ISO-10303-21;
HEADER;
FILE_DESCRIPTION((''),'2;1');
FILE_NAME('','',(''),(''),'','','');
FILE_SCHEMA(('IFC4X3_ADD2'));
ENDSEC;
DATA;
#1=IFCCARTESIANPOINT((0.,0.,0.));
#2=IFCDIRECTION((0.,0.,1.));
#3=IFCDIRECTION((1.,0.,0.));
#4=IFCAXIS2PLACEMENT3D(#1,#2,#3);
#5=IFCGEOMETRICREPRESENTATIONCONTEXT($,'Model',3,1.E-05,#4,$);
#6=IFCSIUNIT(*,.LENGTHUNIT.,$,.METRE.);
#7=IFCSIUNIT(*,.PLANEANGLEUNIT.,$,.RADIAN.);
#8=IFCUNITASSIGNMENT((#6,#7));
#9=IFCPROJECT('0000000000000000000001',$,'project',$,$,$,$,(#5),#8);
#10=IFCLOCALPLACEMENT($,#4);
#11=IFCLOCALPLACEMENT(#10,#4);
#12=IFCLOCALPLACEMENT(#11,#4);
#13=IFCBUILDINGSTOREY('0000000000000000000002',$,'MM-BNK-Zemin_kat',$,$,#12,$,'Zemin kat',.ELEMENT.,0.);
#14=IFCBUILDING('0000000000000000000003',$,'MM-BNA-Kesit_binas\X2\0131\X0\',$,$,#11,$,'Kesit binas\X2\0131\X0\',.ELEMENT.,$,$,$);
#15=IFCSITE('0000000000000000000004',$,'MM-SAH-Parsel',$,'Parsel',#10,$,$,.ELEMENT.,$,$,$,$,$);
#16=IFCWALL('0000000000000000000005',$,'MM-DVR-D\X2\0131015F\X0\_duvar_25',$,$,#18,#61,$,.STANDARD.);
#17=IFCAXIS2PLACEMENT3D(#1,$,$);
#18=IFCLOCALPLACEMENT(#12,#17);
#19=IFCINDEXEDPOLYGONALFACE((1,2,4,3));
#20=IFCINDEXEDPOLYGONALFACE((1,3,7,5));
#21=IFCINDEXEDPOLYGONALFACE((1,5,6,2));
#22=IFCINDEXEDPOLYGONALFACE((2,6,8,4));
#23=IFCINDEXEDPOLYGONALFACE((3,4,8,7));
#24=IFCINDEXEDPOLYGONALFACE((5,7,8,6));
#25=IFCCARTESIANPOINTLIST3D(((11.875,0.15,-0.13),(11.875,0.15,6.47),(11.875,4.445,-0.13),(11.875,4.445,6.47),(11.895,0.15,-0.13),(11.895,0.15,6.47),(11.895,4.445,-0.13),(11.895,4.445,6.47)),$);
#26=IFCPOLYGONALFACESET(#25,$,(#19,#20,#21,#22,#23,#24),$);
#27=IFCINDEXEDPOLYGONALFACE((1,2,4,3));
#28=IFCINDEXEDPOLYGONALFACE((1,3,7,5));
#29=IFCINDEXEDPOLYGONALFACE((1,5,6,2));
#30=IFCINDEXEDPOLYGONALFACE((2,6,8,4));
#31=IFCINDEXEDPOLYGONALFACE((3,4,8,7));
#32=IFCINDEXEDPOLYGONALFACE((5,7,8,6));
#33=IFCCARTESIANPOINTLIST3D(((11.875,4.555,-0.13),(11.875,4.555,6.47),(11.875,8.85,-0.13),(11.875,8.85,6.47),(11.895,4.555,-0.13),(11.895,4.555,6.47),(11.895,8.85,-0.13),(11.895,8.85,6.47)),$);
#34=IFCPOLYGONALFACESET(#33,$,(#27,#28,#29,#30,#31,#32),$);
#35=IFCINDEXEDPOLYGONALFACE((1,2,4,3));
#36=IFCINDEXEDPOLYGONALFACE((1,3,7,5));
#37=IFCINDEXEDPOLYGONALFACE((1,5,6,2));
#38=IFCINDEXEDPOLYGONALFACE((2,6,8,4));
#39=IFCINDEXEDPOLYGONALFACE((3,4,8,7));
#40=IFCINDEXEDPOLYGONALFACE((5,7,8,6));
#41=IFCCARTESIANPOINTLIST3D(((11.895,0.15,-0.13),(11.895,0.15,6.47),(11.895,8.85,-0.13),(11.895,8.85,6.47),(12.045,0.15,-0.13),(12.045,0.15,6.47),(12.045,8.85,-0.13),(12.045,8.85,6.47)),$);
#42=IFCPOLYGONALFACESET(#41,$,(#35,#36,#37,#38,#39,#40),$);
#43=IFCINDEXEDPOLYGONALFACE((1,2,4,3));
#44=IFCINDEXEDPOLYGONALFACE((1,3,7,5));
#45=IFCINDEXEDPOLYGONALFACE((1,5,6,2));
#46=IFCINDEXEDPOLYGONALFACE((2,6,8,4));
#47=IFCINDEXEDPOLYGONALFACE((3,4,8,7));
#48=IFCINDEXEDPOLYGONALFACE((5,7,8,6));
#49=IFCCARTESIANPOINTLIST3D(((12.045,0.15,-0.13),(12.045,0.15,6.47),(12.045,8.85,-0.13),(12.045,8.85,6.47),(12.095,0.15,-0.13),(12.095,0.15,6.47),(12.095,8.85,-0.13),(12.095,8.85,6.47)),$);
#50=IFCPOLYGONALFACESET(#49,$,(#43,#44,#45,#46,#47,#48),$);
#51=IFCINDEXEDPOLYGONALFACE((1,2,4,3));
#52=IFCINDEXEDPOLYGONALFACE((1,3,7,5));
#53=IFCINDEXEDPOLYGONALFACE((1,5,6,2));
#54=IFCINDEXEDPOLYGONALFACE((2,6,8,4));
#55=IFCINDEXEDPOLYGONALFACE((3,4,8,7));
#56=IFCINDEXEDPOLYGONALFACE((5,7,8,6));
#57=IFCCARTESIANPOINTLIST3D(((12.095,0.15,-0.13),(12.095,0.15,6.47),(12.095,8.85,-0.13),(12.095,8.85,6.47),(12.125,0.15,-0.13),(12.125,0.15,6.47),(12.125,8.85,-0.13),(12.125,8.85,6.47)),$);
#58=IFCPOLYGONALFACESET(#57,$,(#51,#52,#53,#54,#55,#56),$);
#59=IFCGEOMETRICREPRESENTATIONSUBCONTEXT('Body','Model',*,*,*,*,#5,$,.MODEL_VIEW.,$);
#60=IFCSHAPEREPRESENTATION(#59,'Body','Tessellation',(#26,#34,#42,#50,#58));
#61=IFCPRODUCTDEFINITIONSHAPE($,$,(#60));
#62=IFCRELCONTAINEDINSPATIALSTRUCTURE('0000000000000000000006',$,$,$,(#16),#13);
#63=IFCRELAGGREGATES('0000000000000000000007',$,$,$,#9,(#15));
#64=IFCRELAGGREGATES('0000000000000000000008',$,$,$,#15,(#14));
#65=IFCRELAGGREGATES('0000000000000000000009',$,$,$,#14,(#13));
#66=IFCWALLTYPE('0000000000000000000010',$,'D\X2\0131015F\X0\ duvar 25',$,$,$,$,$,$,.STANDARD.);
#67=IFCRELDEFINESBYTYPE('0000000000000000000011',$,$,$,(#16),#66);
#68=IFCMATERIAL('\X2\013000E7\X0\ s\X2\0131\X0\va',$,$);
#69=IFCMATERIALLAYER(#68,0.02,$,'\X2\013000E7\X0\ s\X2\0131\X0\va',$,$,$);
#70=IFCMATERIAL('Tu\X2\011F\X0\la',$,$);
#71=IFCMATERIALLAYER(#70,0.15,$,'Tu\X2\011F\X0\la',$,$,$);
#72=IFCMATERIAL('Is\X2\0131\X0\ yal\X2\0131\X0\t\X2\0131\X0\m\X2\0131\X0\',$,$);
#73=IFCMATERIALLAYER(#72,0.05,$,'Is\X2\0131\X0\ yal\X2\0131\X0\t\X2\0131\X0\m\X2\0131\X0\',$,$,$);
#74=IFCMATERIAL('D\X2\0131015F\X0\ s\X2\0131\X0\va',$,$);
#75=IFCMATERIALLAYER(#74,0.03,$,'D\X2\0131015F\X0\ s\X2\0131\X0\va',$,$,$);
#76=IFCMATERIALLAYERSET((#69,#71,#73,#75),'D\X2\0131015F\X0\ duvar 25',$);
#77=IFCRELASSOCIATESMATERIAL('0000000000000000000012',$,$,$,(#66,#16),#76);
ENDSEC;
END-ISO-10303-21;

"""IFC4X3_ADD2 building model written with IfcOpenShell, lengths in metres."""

from ifc_helpers import new_model, si_unit, frame, origin_with_axes, place, context, subcontext, project, spatial, polyline, outline, extrude, material, layer, layer_set, type_object, element, save


model = new_model("IFC4X3_ADD2")

# Units and contexts
model_context = context("Model", 3, precision=1e-05, world=origin_with_axes())
body_context = subcontext(model_context, "Body", "Model", "MODEL_VIEW")
ifc_project = project(units=[si_unit("LENGTHUNIT", "METRE"), si_unit("PLANEANGLEUNIT", "RADIAN")], contexts=[model_context])

# Site, building, storey
site_placement = place(None, origin_with_axes())
site = spatial("IfcSite", under=ifc_project, at=site_placement, Name="MM-SAH-Parsel", ObjectType="Parsel", CompositionType="ELEMENT")
building_placement = place(site_placement, origin_with_axes())
building = spatial("IfcBuilding", under=site, at=building_placement, Name="MM-BNA-Kesit_binası", LongName="Kesit binası", CompositionType="ELEMENT")
storey_placement = place(building_placement, origin_with_axes())
storey = spatial("IfcBuildingStorey", under=building, at=storey_placement, Name="MM-BNK-Zemin_kat", LongName="Zemin kat", CompositionType="ELEMENT", Elevation=0.0)

# Shared definitions
ifc_material_1 = material(Name="İç sıva")
ifc_layer_1 = layer(ifc_material_1, 0.02, Name="İç sıva")
ifc_material_2 = material(Name="Tuğla")
ifc_layer_2 = layer(ifc_material_2, 0.15, Name="Tuğla")
ifc_material_3 = material(Name="Isı yalıtımı")
ifc_layer_3 = layer(ifc_material_3, 0.05, Name="Isı yalıtımı")
ifc_material_4 = material(Name="Dış sıva")
ifc_layer_4 = layer(ifc_material_4, 0.03, Name="Dış sıva")
ifc_layer_set_1 = layer_set([ifc_layer_1, ifc_layer_2, ifc_layer_3, ifc_layer_4], Name="Dış duvar 25")
wall_type_1 = type_object("IfcWallType", Name="Dış duvar 25", PredefinedType="STANDARD", material=ifc_layer_set_1)

# Wall
wall_1_placement = place(storey_placement, origin_with_axes())
element("IfcWall", 1, at=wall_1_placement, inside=storey, type_object=wall_type_1, material=ifc_layer_set_1, Name="MM-DVR-Dış_duvar_25", PredefinedType="STANDARD", context=body_context, shape_type="SweptSolid", body=[
    extrude(outline(polyline([(11.895, 0.15), (11.895, 4.445), (11.875, 4.445), (11.875, 0.15), (11.895, 0.15)])), frame((0.0, 0.0, -0.13)), (0.0, 0.0, 1.0), 6.6),
    extrude(outline(polyline([(11.895, 4.555), (11.895, 8.85), (11.875, 8.85), (11.875, 4.555), (11.895, 4.555)])), frame((0.0, 0.0, -0.13)), (0.0, 0.0, 1.0), 6.6),
    extrude(outline(polyline([(12.045, 0.15), (12.045, 8.85), (11.895, 8.85), (11.895, 0.15), (12.045, 0.15)])), frame((0.0, 0.0, -0.13)), (0.0, 0.0, 1.0), 6.6),
    extrude(outline(polyline([(12.095, 0.15), (12.095, 8.85), (12.045, 8.85), (12.045, 0.15), (12.095, 0.15)])), frame((0.0, 0.0, -0.13)), (0.0, 0.0, 1.0), 6.6),
    extrude(outline(polyline([(12.125, 0.15), (12.125, 8.85), (12.095, 8.85), (12.095, 0.15), (12.125, 0.15)])), frame((0.0, 0.0, -0.13)), (0.0, 0.0, 1.0), 6.6),
])

save(model, "model.ifc")
